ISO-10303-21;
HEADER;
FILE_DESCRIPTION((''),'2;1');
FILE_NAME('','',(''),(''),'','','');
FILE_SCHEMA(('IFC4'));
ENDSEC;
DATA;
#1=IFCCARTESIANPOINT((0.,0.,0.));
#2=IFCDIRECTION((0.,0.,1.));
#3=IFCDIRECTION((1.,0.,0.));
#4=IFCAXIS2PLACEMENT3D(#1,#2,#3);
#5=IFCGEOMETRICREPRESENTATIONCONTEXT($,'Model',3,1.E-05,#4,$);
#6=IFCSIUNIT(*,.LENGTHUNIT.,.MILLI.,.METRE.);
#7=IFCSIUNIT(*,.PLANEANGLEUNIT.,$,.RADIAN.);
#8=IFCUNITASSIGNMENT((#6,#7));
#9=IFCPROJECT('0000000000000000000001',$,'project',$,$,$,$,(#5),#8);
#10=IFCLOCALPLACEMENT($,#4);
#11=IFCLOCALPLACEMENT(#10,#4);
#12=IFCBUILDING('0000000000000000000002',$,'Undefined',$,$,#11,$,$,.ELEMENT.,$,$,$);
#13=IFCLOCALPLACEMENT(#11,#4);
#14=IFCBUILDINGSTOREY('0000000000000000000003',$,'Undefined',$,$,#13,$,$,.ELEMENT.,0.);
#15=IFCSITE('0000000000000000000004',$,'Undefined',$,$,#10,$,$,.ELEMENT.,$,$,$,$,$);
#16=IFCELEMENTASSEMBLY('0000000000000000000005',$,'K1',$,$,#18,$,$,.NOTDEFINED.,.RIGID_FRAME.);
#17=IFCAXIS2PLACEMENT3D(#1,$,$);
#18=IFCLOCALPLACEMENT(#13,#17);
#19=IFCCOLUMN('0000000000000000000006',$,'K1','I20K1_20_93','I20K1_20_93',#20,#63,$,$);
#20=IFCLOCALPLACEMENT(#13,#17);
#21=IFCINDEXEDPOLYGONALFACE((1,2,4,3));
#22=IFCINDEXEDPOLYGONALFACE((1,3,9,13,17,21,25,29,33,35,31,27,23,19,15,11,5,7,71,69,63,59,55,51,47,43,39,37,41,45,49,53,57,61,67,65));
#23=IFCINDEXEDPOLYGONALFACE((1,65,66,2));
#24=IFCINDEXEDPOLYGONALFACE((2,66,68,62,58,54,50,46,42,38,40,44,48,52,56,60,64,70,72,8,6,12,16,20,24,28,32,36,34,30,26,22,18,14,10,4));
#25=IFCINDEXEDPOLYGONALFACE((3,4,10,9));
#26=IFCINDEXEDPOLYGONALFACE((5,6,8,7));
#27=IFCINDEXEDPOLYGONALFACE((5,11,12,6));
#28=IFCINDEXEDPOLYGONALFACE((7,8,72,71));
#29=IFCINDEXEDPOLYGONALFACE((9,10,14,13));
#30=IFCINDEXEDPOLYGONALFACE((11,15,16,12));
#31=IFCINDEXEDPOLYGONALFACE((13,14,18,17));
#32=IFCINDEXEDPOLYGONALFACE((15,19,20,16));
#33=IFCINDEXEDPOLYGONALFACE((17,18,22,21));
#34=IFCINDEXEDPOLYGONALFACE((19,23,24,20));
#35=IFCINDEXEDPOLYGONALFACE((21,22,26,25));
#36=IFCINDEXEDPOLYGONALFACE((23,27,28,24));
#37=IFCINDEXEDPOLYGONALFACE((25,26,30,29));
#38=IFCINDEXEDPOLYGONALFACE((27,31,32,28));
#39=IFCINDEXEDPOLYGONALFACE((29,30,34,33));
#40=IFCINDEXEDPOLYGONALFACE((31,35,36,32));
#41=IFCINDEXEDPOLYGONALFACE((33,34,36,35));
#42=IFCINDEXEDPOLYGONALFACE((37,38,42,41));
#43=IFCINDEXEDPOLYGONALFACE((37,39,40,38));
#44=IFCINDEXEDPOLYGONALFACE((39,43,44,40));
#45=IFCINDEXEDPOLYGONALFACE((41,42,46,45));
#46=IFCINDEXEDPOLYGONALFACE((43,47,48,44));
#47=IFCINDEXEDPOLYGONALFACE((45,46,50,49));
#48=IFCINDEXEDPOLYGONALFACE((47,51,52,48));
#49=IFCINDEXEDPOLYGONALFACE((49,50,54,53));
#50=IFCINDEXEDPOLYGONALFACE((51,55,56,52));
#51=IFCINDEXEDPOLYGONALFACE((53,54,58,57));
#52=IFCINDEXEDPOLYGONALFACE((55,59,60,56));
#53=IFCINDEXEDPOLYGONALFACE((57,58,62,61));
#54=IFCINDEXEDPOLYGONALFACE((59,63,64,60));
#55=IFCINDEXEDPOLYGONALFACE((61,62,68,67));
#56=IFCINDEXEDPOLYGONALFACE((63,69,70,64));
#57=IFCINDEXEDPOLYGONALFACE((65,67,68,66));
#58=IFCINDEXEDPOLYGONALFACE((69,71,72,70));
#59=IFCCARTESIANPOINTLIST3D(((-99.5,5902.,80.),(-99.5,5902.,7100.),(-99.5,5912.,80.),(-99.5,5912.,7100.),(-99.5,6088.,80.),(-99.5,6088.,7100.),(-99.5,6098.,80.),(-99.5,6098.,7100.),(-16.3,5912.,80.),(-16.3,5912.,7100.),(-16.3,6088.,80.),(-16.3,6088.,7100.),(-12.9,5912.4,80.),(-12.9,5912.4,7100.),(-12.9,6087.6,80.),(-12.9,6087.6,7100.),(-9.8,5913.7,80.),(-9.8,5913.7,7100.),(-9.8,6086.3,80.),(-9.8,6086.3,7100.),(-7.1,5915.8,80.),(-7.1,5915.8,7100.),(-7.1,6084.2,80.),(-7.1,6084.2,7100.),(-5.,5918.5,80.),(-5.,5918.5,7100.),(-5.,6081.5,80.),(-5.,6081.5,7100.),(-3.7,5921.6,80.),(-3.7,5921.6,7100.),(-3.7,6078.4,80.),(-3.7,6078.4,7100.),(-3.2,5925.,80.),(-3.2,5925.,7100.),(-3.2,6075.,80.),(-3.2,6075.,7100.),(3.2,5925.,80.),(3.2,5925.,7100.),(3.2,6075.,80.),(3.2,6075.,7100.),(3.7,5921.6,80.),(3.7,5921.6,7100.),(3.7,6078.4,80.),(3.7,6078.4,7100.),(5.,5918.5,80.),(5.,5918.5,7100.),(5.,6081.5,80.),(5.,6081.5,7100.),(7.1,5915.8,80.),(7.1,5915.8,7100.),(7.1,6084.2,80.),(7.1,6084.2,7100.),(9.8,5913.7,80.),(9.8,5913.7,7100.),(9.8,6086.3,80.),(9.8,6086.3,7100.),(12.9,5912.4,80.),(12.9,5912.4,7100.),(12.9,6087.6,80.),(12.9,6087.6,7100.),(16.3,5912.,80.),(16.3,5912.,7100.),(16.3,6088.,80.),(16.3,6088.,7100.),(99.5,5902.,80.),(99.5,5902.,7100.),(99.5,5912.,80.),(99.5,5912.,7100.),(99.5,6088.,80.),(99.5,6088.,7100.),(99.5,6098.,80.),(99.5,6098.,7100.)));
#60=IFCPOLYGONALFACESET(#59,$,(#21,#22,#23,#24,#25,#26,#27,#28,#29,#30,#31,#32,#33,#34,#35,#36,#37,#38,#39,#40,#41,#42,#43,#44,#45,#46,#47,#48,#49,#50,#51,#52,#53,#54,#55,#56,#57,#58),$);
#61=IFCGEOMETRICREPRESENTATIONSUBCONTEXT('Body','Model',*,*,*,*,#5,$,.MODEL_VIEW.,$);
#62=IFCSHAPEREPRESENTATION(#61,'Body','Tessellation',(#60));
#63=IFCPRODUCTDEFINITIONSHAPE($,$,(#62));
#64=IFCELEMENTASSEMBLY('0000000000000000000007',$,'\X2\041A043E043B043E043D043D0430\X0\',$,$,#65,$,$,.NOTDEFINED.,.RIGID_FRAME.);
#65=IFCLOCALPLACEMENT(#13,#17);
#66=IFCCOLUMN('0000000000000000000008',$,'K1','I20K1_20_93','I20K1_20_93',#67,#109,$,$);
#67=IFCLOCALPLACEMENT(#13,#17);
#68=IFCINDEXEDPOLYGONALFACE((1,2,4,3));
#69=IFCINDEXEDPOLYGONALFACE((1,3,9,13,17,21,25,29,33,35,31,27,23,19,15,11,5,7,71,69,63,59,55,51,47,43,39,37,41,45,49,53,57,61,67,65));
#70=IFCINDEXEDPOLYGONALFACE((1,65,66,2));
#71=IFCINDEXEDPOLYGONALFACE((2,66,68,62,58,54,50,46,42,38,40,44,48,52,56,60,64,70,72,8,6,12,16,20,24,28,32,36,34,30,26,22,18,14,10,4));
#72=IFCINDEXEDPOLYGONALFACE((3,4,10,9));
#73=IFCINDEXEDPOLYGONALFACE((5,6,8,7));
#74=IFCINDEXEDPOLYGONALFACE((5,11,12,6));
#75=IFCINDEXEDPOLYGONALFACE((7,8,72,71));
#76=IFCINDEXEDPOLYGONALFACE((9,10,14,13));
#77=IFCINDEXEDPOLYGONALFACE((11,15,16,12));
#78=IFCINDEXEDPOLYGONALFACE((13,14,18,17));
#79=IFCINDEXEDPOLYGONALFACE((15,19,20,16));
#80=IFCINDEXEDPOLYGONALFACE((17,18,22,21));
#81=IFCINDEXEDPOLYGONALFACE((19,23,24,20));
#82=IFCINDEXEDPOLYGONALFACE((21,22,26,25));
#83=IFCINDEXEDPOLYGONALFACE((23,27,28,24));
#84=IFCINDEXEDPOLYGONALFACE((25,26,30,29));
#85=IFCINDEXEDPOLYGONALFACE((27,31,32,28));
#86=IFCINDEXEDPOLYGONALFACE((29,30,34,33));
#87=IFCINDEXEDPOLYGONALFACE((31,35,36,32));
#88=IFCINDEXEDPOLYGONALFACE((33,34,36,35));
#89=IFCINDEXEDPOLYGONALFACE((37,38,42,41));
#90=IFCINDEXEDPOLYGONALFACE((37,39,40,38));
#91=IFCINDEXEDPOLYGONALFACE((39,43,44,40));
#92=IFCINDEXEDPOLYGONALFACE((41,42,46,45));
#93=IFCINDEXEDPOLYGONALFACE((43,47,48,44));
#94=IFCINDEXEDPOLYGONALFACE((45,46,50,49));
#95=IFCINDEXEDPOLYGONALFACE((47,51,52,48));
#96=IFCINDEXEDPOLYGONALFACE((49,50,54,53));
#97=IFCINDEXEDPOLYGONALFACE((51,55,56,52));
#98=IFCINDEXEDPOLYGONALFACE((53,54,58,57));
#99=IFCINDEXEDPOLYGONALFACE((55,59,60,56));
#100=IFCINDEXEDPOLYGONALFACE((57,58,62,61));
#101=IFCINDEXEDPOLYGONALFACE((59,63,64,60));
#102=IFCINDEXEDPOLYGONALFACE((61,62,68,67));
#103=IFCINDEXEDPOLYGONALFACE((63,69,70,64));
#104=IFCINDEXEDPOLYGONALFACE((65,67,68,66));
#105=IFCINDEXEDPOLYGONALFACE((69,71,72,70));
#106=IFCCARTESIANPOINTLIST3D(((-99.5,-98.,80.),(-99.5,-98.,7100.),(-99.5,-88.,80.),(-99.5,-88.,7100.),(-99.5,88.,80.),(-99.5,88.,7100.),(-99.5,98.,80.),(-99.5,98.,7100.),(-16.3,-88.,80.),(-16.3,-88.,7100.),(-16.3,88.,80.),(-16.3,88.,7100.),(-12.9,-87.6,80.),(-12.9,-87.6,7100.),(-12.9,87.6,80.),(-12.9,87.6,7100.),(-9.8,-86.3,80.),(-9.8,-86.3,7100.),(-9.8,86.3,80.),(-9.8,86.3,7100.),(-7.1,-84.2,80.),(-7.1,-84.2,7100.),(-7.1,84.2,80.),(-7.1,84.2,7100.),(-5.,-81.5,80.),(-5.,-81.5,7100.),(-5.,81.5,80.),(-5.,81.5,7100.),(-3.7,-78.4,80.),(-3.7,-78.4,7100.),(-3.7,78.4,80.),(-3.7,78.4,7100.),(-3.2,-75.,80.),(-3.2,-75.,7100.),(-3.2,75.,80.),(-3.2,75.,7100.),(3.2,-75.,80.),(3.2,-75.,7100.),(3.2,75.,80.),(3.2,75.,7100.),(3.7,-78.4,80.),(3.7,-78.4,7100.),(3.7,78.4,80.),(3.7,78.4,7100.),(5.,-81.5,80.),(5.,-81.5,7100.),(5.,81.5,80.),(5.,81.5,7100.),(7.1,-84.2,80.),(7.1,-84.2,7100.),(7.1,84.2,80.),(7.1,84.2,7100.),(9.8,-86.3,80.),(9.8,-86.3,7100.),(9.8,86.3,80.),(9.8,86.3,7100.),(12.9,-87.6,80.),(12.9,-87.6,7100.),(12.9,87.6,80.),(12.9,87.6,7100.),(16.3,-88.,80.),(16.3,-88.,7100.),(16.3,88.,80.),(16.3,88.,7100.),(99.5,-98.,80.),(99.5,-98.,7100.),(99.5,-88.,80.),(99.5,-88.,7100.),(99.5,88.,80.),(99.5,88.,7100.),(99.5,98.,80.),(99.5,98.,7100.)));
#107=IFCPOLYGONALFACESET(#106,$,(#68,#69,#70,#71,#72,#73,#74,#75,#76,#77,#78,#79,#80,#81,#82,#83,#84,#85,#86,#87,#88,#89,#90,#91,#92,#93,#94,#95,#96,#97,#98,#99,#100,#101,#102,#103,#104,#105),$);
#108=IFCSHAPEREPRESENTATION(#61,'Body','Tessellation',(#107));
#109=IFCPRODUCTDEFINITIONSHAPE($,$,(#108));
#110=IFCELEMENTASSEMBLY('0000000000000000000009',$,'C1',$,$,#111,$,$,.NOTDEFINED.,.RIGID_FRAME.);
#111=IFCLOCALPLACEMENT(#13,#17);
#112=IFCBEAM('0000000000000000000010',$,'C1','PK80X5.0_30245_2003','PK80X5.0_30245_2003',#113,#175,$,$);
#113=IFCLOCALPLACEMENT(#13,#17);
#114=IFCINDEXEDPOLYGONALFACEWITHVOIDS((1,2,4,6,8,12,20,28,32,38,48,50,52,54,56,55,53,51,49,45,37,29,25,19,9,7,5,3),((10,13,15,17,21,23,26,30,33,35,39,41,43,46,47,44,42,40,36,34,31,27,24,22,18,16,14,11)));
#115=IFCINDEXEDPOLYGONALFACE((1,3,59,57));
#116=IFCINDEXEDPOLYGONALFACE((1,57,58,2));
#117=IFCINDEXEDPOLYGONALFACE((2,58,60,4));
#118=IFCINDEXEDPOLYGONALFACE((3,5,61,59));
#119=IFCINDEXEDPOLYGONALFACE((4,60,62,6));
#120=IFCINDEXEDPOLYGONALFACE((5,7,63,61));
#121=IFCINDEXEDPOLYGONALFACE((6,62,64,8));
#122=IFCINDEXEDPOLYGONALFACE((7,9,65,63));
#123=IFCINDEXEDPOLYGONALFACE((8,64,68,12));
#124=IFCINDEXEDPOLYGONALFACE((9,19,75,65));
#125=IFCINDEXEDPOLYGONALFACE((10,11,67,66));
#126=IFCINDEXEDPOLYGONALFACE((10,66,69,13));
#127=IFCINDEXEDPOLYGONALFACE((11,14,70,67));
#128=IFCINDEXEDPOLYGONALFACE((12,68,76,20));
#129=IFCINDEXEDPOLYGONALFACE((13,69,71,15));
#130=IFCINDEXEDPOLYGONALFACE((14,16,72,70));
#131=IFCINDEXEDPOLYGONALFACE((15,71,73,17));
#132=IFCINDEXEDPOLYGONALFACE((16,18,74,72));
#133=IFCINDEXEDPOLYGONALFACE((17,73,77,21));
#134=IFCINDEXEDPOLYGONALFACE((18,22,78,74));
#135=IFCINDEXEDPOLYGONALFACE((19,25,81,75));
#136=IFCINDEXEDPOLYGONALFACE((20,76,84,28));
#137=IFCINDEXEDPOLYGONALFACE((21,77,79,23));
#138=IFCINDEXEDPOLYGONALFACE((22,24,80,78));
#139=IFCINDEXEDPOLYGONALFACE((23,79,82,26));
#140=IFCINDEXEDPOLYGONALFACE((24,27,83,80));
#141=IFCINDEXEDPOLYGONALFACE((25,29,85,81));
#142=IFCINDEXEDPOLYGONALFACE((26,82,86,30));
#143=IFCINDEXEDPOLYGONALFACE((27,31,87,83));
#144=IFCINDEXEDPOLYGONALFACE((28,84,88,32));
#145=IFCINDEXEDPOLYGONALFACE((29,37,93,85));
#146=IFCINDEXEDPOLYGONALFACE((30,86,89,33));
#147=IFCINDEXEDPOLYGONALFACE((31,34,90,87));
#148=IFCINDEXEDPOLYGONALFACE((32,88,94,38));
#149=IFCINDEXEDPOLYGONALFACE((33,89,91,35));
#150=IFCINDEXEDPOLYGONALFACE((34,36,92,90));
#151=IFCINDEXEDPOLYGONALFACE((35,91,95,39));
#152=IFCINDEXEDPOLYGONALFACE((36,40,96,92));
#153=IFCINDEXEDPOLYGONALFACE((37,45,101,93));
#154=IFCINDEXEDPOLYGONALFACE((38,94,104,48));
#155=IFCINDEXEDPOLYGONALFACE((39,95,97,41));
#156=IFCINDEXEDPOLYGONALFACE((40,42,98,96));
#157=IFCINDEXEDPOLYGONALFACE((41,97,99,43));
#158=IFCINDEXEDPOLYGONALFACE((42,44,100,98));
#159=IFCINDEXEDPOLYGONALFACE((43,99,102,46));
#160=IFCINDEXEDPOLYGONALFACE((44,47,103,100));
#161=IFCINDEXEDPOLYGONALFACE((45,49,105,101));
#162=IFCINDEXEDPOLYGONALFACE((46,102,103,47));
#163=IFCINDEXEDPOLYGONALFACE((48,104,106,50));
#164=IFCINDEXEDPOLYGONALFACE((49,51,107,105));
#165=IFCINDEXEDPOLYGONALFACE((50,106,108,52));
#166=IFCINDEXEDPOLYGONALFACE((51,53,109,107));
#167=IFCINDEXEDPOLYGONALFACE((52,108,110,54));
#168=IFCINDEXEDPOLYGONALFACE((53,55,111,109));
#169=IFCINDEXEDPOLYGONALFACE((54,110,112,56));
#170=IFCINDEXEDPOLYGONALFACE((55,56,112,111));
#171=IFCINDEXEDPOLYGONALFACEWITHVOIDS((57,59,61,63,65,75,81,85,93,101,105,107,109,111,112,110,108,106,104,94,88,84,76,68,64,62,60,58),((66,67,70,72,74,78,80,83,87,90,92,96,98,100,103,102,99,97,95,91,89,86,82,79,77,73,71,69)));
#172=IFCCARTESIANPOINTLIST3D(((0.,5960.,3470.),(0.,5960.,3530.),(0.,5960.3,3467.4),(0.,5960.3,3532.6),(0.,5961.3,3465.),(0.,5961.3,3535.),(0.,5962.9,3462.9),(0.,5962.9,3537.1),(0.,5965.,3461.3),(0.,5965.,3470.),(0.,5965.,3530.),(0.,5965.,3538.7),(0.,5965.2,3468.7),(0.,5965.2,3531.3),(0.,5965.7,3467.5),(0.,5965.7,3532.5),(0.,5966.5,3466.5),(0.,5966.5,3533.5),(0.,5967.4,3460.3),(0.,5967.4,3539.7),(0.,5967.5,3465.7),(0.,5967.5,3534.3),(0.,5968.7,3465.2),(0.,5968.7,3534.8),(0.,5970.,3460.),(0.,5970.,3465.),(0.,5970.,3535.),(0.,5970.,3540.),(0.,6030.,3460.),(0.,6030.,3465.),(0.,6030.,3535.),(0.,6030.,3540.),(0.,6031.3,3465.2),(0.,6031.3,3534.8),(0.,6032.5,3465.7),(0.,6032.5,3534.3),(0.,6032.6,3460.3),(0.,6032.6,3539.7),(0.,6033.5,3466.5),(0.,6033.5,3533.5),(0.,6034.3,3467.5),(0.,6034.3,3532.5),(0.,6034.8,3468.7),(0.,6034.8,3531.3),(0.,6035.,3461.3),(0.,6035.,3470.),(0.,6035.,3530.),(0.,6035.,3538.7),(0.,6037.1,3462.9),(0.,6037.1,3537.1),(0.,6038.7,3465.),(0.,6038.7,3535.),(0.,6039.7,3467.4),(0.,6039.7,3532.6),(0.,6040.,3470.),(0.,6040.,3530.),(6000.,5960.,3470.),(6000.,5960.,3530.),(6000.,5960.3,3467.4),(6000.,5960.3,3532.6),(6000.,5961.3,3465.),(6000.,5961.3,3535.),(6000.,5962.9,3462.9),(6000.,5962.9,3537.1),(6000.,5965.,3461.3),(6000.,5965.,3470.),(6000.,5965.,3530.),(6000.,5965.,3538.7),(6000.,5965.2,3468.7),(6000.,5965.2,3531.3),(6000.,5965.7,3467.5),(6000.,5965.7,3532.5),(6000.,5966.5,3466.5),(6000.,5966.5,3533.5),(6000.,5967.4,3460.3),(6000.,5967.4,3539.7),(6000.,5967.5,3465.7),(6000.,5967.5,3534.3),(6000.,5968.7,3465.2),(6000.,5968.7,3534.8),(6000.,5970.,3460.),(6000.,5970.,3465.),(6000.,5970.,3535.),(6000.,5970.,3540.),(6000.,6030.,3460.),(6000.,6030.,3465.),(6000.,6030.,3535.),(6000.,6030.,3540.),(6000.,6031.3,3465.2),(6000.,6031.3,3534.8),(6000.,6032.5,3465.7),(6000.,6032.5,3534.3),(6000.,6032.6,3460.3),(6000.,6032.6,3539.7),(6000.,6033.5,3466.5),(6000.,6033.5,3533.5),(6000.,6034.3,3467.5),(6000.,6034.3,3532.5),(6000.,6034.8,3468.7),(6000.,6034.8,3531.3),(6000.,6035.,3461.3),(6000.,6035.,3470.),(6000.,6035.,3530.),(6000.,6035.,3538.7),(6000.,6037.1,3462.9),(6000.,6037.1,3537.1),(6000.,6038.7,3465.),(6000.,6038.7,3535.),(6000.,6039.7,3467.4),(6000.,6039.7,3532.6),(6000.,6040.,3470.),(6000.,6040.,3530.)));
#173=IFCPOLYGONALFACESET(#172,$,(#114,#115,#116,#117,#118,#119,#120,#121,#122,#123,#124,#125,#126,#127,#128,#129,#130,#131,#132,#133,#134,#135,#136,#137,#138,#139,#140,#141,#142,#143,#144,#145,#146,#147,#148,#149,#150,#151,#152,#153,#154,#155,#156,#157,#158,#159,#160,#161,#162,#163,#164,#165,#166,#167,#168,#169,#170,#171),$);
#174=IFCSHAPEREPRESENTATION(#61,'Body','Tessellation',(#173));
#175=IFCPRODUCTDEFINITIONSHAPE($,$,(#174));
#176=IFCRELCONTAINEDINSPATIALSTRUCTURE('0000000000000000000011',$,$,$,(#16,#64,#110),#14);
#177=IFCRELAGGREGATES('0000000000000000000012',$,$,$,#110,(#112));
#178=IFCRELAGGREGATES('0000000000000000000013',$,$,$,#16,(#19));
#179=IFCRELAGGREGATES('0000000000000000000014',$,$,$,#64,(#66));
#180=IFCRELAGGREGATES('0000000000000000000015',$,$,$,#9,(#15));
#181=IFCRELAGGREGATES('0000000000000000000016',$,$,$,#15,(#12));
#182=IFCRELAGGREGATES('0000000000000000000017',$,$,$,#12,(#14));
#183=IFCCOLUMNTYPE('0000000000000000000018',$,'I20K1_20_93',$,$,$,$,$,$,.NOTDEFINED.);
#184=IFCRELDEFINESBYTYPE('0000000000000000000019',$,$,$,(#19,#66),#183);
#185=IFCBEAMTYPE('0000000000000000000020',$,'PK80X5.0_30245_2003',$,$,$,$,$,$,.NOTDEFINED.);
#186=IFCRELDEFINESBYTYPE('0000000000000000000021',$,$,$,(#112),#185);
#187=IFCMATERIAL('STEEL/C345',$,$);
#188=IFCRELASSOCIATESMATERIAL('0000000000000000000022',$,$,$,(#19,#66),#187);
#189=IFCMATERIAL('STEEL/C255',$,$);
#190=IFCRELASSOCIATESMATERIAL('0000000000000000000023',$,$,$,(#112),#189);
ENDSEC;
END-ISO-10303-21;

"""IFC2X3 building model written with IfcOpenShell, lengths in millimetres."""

from ifc_helpers import new_model, si_unit, frame, origin_with_axes, origin_2d_with_axis, place, context, subcontext, project, spatial, hollow_rectangle, i_section, extrude, material, type_object, element, aggregate, save


model = new_model("IFC2X3")

# Units and contexts
model_context = context("Model", 3, precision=1e-05, world=origin_with_axes())
body_context = subcontext(model_context, "Body", "Model", "MODEL_VIEW")
ifc_project = project(units=[si_unit("LENGTHUNIT", "METRE", prefix="MILLI"), si_unit("PLANEANGLEUNIT", "RADIAN")], contexts=[model_context])

# Site, building, storey
site_placement = place(None, origin_with_axes())
site = spatial("IfcSite", under=ifc_project, at=site_placement, Name="Undefined", CompositionType="ELEMENT")
building_placement = place(site_placement, origin_with_axes())
building = spatial("IfcBuilding", under=site, at=building_placement, Name="Undefined", CompositionType="ELEMENT")
storey_placement = place(building_placement, origin_with_axes())
storey = spatial("IfcBuildingStorey", under=building, at=storey_placement, Name="Undefined", CompositionType="ELEMENT", Elevation=0.0)

# Element assemblies, columns
assembly_1_placement = place(storey_placement, origin_with_axes())
assembly_1 = element("IfcElementAssembly", 1, at=assembly_1_placement, inside=storey, Name="K1", AssemblyPlace="NOTDEFINED", PredefinedType="RIGID_FRAME")
ifc_material_1 = material(Name="STEEL/C345")
column_type_1 = type_object("IfcColumnType", Name="I20K1_20_93", PredefinedType="NOTDEFINED")
column_1_placement = place(assembly_1_placement, frame((0.0, 6000.0, 80.0), z_axis=(0.0, 0.0, 1.0), x_axis=(0.0, 1.0, 0.0)))
column_1 = element("IfcColumn", 2, at=column_1_placement, type_object=column_type_1, material=ifc_material_1, Name="K1", Description="I20K1_20_93", ObjectType="I20K1_20_93", context=body_context, shape_type="SweptSolid", body=[
    extrude(i_section(OverallWidth=199.0, OverallDepth=196.0, WebThickness=6.5, FlangeThickness=10.0, FilletRadius=13.0, at=origin_2d_with_axis()), frame((0.0, 0.0, 7020.0), z_axis=(0.0, 0.0, -1.0), x_axis=(0.0, 1.0, 0.0)), (0.0, 0.0, 1.0), 7020.0),
])
assembly_2_placement = place(storey_placement, origin_with_axes())
assembly_2 = element("IfcElementAssembly", 3, at=assembly_2_placement, inside=storey, Name="Колонна", AssemblyPlace="NOTDEFINED", PredefinedType="RIGID_FRAME")
column_2_placement = place(assembly_2_placement, frame((0.0, 0.0, 80.0), z_axis=(0.0, 0.0, 1.0), x_axis=(0.0, 1.0, 0.0)))
column_2 = element("IfcColumn", 4, at=column_2_placement, type_object=column_type_1, material=ifc_material_1, Name="K1", Description="I20K1_20_93", ObjectType="I20K1_20_93", context=body_context, shape_type="SweptSolid", body=[
    extrude(i_section(OverallWidth=199.0, OverallDepth=196.0, WebThickness=6.5, FlangeThickness=10.0, FilletRadius=13.0, at=origin_2d_with_axis()), frame((0.0, 0.0, 7020.0), z_axis=(0.0, 0.0, -1.0), x_axis=(0.0, 1.0, 0.0)), (0.0, 0.0, 1.0), 7020.0),
])

# Element assembly, beam
assembly_3_placement = place(storey_placement, origin_with_axes())
assembly_3 = element("IfcElementAssembly", 5, at=assembly_3_placement, inside=storey, Name="C1", AssemblyPlace="NOTDEFINED", PredefinedType="RIGID_FRAME")
ifc_material_2 = material(Name="STEEL/C255")
beam_type_1 = type_object("IfcBeamType", Name="PK80X5.0_30245_2003", PredefinedType="NOTDEFINED")
beam_1_placement = place(assembly_3_placement, frame((0.0, 6000.0, 3500.0), z_axis=(0.0, 0.0, -1.0), x_axis=(1.0, 0.0, 0.0)))
beam_1 = element("IfcBeam", 6, at=beam_1_placement, type_object=beam_type_1, material=ifc_material_2, Name="C1", Description="PK80X5.0_30245_2003", ObjectType="PK80X5.0_30245_2003", context=body_context, shape_type="SweptSolid", body=[
    extrude(hollow_rectangle(XDim=80.0, YDim=80.0, WallThickness=5.0, InnerFilletRadius=5.0, OuterFilletRadius=10.0, at=origin_2d_with_axis()), frame((6000.0, 0.0, 0.0), z_axis=(-1.0, 0.0, 0.0), x_axis=(0.0, -1.0, 0.0)), (0.0, 0.0, 1.0), 6000.0),
])
aggregate(assembly_3, [beam_1])

aggregate(assembly_1, [column_1])
aggregate(assembly_2, [column_2])

save(model, "model.ifc")
